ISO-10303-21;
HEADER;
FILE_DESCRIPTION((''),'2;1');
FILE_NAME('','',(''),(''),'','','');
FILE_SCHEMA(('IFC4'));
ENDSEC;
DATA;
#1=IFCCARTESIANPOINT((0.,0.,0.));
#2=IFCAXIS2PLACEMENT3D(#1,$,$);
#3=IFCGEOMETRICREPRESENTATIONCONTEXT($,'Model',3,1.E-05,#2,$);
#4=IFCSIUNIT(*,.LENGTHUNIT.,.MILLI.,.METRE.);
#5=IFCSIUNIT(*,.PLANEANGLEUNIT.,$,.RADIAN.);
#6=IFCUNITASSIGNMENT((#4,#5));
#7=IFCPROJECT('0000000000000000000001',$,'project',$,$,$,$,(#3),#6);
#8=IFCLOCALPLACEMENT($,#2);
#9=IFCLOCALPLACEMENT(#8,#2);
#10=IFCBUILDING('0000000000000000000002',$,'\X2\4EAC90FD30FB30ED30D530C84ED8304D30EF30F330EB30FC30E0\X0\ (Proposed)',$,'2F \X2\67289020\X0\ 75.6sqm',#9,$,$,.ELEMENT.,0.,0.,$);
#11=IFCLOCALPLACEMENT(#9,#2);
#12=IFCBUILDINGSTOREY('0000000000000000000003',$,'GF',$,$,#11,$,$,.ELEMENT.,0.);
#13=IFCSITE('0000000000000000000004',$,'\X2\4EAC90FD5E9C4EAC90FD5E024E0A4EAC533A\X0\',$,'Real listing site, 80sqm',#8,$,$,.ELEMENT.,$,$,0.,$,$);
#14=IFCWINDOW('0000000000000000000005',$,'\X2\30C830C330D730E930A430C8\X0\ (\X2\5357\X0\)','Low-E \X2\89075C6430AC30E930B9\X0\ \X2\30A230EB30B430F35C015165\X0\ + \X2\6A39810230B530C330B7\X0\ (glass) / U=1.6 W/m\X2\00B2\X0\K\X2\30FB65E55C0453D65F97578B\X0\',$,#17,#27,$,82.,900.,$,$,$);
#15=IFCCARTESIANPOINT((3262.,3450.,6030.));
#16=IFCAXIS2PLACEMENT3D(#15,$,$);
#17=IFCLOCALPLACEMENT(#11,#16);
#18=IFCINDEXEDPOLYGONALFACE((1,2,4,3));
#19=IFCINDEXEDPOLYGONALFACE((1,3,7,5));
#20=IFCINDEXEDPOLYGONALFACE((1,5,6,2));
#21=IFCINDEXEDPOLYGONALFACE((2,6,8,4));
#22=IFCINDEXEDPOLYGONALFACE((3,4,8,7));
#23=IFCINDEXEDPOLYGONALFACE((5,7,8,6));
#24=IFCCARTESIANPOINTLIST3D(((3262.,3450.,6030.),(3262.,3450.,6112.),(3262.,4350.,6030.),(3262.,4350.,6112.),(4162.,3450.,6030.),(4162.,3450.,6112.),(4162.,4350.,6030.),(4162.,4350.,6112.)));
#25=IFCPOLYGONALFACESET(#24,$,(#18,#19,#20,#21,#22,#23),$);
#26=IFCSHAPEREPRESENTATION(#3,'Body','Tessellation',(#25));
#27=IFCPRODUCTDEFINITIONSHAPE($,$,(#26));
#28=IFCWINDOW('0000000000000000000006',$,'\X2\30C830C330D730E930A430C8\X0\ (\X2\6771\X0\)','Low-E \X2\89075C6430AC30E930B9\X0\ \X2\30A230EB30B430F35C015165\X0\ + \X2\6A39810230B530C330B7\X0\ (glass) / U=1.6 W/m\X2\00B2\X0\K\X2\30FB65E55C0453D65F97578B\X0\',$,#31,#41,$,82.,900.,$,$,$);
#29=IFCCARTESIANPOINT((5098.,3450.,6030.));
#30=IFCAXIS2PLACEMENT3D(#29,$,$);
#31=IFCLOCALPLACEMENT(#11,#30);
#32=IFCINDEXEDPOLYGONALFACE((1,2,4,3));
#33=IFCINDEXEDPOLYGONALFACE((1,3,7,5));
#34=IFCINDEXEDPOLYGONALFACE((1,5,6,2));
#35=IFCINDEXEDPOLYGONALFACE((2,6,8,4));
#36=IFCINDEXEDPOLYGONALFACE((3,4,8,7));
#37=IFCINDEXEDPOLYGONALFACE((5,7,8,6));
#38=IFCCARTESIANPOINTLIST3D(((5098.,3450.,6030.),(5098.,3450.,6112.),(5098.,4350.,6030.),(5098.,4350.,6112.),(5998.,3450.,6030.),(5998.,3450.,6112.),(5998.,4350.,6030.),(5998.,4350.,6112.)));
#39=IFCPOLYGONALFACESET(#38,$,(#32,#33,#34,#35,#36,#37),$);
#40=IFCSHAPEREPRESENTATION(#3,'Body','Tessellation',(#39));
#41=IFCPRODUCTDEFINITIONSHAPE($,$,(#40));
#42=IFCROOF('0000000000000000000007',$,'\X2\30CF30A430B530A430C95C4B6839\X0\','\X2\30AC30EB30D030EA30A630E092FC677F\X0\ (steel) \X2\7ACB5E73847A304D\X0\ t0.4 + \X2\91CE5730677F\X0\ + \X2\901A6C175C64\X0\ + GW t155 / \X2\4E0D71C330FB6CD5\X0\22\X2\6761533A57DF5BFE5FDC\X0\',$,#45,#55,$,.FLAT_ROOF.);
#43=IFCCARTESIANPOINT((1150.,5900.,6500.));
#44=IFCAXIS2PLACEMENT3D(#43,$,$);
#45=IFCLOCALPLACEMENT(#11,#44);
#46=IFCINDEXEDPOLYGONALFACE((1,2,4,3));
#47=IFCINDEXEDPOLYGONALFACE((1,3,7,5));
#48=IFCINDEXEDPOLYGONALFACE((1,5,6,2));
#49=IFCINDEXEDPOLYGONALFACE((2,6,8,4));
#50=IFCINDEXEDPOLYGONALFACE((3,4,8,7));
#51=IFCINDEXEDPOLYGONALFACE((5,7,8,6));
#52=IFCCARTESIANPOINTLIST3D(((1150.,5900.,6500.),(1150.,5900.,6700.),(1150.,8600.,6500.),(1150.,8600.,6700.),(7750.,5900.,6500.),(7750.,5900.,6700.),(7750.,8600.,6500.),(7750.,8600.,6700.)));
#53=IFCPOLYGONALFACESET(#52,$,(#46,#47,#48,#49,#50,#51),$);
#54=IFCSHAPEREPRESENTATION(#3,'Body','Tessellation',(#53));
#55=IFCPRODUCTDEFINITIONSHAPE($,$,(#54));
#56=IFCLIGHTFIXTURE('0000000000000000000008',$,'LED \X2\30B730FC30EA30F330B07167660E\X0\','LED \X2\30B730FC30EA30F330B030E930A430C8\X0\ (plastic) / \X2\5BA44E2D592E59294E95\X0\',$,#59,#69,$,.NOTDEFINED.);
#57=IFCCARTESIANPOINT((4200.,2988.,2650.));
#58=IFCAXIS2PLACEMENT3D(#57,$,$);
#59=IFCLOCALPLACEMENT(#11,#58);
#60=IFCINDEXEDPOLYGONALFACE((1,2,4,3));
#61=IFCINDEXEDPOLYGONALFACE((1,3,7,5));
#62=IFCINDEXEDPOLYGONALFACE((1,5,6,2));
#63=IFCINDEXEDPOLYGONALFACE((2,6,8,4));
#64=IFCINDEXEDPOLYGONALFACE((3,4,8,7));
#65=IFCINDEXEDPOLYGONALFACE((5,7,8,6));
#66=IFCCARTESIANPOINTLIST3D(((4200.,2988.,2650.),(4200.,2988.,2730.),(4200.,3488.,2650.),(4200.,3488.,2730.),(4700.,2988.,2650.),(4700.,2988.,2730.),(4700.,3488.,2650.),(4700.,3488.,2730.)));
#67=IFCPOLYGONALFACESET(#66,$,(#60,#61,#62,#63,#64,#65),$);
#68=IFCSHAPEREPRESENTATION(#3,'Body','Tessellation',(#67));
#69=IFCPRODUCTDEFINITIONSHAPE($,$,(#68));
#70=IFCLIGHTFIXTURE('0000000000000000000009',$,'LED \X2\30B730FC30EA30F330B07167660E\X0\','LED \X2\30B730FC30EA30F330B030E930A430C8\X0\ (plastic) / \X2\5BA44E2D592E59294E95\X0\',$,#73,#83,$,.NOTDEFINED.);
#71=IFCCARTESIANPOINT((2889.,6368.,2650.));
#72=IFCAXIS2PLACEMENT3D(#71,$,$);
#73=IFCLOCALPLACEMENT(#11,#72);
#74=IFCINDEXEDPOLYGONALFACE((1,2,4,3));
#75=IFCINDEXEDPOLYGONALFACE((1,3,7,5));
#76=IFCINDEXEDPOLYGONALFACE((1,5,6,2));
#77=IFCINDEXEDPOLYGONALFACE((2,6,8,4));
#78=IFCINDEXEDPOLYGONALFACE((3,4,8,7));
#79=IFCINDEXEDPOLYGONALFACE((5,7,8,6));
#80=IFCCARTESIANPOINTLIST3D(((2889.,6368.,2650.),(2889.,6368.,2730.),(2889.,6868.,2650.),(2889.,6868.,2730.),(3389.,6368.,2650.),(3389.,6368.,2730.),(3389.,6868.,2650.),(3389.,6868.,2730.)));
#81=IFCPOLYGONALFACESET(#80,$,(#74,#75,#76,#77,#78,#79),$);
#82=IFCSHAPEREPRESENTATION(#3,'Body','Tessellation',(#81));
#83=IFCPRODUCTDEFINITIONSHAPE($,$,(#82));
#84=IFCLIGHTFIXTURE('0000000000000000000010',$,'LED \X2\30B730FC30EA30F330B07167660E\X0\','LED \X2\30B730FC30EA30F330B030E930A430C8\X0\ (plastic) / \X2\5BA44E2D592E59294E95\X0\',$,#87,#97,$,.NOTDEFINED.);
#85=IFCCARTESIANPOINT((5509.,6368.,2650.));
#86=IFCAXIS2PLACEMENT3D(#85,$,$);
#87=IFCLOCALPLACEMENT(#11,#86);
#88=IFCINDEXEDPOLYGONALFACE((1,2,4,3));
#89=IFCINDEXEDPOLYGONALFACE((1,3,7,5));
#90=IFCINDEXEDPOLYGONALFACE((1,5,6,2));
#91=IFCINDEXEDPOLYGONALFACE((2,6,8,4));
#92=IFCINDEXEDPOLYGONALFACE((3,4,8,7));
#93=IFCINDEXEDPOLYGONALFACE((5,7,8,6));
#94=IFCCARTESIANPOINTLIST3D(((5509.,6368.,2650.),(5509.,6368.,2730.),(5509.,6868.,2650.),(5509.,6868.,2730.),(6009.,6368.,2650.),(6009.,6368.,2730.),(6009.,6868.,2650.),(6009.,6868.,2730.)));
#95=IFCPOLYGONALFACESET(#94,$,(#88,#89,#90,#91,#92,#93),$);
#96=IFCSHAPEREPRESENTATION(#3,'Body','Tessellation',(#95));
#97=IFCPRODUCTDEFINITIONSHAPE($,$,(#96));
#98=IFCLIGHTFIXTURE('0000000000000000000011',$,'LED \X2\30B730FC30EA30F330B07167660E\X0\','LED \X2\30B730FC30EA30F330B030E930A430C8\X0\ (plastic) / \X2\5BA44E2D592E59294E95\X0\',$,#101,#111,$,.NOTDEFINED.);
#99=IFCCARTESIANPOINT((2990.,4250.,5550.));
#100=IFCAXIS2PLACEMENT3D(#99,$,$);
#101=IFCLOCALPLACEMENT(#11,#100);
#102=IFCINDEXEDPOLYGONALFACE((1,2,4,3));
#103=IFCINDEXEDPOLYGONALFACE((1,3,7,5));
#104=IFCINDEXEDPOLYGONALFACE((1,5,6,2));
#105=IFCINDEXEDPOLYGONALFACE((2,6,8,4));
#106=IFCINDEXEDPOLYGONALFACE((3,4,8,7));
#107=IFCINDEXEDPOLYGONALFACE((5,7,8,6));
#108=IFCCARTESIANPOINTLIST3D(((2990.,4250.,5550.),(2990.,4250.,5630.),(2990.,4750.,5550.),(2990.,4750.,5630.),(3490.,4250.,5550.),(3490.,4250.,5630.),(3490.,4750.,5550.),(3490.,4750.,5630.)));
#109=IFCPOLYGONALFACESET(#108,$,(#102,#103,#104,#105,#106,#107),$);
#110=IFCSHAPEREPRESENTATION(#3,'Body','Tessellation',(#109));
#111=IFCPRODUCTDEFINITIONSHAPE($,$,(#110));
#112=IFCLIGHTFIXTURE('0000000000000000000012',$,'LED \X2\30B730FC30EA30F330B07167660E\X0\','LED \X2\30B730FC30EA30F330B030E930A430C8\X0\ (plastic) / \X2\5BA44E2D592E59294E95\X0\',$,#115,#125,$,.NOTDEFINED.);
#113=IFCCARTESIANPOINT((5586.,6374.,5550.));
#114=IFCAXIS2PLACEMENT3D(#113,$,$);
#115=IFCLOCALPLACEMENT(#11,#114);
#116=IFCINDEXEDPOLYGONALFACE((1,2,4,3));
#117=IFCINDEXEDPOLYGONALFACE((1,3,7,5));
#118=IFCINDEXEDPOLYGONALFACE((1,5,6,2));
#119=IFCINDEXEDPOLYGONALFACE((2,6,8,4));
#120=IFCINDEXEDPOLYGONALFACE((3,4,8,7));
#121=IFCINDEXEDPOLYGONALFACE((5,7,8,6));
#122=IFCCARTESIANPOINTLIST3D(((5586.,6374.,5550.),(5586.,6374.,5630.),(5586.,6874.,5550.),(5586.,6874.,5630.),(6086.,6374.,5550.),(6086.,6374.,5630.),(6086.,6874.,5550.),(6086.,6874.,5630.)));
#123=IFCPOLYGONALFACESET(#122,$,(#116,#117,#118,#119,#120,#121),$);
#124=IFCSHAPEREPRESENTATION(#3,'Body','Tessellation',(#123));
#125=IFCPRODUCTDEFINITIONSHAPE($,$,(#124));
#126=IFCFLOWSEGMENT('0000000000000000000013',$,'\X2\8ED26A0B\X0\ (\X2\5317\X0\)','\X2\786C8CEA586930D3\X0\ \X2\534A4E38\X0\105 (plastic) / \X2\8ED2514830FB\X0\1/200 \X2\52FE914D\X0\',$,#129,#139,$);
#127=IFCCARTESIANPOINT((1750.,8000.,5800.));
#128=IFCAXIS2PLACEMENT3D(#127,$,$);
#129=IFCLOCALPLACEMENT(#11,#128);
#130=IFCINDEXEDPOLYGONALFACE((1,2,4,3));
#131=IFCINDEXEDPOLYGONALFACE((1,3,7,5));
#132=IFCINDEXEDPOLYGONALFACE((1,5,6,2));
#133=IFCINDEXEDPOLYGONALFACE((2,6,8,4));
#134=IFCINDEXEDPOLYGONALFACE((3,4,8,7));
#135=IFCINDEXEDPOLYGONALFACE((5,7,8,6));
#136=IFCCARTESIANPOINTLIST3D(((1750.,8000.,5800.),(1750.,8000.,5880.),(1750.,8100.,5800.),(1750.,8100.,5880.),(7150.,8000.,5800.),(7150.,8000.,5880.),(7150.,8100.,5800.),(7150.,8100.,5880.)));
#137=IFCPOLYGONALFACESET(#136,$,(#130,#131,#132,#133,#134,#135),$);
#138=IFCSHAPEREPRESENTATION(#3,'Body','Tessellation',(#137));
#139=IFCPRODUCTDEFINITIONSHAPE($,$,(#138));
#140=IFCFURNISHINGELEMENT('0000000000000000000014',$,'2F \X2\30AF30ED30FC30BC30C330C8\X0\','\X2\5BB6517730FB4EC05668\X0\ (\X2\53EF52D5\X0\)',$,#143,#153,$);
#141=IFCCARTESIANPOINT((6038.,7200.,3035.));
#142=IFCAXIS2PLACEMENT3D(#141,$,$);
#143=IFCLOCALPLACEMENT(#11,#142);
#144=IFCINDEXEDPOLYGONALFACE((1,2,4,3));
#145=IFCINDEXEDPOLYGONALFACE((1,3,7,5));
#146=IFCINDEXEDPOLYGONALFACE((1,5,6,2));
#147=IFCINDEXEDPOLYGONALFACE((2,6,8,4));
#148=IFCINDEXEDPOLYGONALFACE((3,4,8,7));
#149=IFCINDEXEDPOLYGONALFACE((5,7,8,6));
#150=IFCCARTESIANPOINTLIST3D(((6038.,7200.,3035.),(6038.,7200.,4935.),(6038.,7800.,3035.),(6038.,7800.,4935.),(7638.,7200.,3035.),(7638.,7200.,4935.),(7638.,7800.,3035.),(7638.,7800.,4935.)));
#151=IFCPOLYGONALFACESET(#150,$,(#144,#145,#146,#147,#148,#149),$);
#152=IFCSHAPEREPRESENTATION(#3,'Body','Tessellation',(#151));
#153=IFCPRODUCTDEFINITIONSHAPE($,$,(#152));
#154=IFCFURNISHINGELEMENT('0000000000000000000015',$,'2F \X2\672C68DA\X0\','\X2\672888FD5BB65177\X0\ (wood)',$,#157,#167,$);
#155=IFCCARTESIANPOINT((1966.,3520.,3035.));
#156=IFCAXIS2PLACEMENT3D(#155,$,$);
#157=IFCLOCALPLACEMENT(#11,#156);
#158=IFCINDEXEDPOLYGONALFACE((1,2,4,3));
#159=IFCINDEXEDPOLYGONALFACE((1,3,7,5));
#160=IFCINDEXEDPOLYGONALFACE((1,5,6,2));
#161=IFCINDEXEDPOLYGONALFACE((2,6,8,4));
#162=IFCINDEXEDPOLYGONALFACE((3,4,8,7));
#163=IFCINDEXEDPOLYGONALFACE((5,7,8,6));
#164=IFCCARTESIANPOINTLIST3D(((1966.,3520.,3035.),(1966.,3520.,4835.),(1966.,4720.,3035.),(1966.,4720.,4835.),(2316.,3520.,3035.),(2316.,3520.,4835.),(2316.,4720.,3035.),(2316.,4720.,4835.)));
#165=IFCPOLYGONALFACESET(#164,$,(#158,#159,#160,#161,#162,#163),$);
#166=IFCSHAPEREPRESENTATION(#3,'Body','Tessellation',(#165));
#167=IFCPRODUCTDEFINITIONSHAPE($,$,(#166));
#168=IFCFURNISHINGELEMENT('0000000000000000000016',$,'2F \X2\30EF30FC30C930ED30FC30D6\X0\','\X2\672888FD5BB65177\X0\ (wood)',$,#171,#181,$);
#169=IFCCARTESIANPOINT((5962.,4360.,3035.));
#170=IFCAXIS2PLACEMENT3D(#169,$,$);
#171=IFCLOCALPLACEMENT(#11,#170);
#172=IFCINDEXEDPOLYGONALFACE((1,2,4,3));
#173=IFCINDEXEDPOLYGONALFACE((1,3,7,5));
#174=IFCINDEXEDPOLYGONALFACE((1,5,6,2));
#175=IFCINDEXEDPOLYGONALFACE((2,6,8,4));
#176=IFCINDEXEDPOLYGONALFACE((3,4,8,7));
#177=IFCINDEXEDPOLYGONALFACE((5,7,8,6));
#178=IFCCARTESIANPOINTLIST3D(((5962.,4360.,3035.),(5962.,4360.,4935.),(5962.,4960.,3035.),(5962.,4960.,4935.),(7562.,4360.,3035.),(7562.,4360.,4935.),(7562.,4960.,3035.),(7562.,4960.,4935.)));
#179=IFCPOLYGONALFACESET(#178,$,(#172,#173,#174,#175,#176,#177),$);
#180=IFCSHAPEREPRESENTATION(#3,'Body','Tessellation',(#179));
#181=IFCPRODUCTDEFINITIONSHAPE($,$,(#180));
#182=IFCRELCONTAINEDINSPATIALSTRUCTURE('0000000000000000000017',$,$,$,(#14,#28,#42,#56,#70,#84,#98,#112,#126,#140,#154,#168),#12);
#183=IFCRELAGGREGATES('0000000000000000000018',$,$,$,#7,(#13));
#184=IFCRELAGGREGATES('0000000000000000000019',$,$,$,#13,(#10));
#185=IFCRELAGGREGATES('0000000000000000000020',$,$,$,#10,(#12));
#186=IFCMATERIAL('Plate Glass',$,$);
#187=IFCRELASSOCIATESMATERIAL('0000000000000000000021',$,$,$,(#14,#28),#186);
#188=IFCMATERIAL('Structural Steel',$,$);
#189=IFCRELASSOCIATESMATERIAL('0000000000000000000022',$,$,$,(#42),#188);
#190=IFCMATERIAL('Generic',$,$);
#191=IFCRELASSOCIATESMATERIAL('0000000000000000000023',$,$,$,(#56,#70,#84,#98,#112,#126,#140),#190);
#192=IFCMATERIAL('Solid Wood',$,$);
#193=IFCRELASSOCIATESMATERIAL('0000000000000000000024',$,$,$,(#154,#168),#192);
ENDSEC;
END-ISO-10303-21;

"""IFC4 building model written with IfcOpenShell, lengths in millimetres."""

from ifc_helpers import new_model, si_unit, frame, frame_2d, origin, place, context, project, spatial, rectangle, extrude, material, element, save


model = new_model("IFC4")

# Units and contexts
model_context = context("Model", 3, precision=1e-05, world=origin())
ifc_project = project(units=[si_unit("LENGTHUNIT", "METRE", prefix="MILLI"), si_unit("PLANEANGLEUNIT", "RADIAN")], contexts=[model_context])

# Site, building, storey
site_placement = place(None, origin())
site = spatial("IfcSite", under=ifc_project, at=site_placement, Name="京都府京都市上京区", ObjectType="Real listing site, 80sqm", CompositionType="ELEMENT", RefElevation=0.0)
building_placement = place(site_placement, origin())
building = spatial("IfcBuilding", under=site, at=building_placement, Name="京都・ロフト付きワンルーム (Proposed)", ObjectType="2F 木造 75.6sqm", CompositionType="ELEMENT", ElevationOfRefHeight=0.0, ElevationOfTerrain=0.0)
storey_placement = place(building_placement, origin())
storey = spatial("IfcBuildingStorey", under=building, at=storey_placement, Name="GF", CompositionType="ELEMENT", Elevation=0.0)

# Shared definitions
ifc_material_1 = material(Name="Solid Wood")

# Shared definitions
ifc_material_2 = material(Name="Plate Glass")

# Windows
window_1_placement = place(storey_placement, frame((3262.0, 3450.0, 6030.0)))
element("IfcWindow", 1, at=window_1_placement, inside=storey, material=ifc_material_2, Name="トップライト (南)", Description="Low-E 複層ガラス アルゴン封入 + 樹脂サッシ (glass) / U=1.6 W/m²K・日射取得型", OverallHeight=82.0, OverallWidth=900.0, context=model_context, shape_type="SweptSolid", body=[
    extrude(rectangle(XDim=900.0, YDim=900.0, at=frame_2d((450.0, 450.0))), frame((3262.0, 3450.0, 6030.0)), (0.0, 0.0, 1.0), 82.0),
])
window_2_placement = place(storey_placement, frame((5098.0, 3450.0, 6030.0)))
element("IfcWindow", 2, at=window_2_placement, inside=storey, material=ifc_material_2, Name="トップライト (東)", Description="Low-E 複層ガラス アルゴン封入 + 樹脂サッシ (glass) / U=1.6 W/m²K・日射取得型", OverallHeight=82.0, OverallWidth=900.0, context=model_context, shape_type="SweptSolid", body=[
    extrude(rectangle(XDim=900.0, YDim=900.0, at=frame_2d((450.0, 450.0))), frame((5098.0, 3450.0, 6030.0)), (0.0, 0.0, 1.0), 82.0),
])

# Roof
ifc_material_3 = material(Name="Structural Steel")
roof_placement = place(storey_placement, frame((1150.0, 5900.0, 6500.0)))
element("IfcRoof", 3, at=roof_placement, inside=storey, material=ifc_material_3, Name="ハイサイド屋根", Description="ガルバリウム鋼板 (steel) 立平葺き t0.4 + 野地板 + 通気層 + GW t155 / 不燃・法22条区域対応", PredefinedType="FLAT_ROOF", context=model_context, shape_type="SweptSolid", body=[
    extrude(rectangle(XDim=6600.0, YDim=2700.0, at=frame_2d((3300.0, 1350.0))), frame((1150.0, 5900.0, 6500.0)), (0.0, 0.0, 1.0), 200.0),
])

# Light fixtures
ifc_material_4 = material(Name="Generic")
light_fixture_1_placement = place(storey_placement, frame((4200.0, 2988.0, 2650.0)))
element("IfcLightFixture", 4, at=light_fixture_1_placement, inside=storey, material=ifc_material_4, Name="LED シーリング照明", Description="LED シーリングライト (plastic) / 室中央天井", PredefinedType="NOTDEFINED", context=model_context, shape_type="SweptSolid", body=[
    extrude(rectangle(XDim=500.0, YDim=500.0, at=frame_2d((250.0, 250.0))), frame((4200.0, 2988.0, 2650.0)), (0.0, 0.0, 1.0), 80.0),
])
light_fixture_2_placement = place(storey_placement, frame((2889.0, 6368.0, 2650.0)))
element("IfcLightFixture", 5, at=light_fixture_2_placement, inside=storey, material=ifc_material_4, Name="LED シーリング照明", Description="LED シーリングライト (plastic) / 室中央天井", PredefinedType="NOTDEFINED", context=model_context, shape_type="SweptSolid", body=[
    extrude(rectangle(XDim=500.0, YDim=500.0, at=frame_2d((250.0, 250.0))), frame((2889.0, 6368.0, 2650.0)), (0.0, 0.0, 1.0), 80.0),
])
light_fixture_3_placement = place(storey_placement, frame((5509.0, 6368.0, 2650.0)))
element("IfcLightFixture", 6, at=light_fixture_3_placement, inside=storey, material=ifc_material_4, Name="LED シーリング照明", Description="LED シーリングライト (plastic) / 室中央天井", PredefinedType="NOTDEFINED", context=model_context, shape_type="SweptSolid", body=[
    extrude(rectangle(XDim=500.0, YDim=500.0, at=frame_2d((250.0, 250.0))), frame((5509.0, 6368.0, 2650.0)), (0.0, 0.0, 1.0), 80.0),
])
light_fixture_4_placement = place(storey_placement, frame((2990.0, 4250.0, 5550.0)))
element("IfcLightFixture", 7, at=light_fixture_4_placement, inside=storey, material=ifc_material_4, Name="LED シーリング照明", Description="LED シーリングライト (plastic) / 室中央天井", PredefinedType="NOTDEFINED", context=model_context, shape_type="SweptSolid", body=[
    extrude(rectangle(XDim=500.0, YDim=500.0, at=frame_2d((250.0, 250.0))), frame((2990.0, 4250.0, 5550.0)), (0.0, 0.0, 1.0), 80.0),
])
light_fixture_5_placement = place(storey_placement, frame((5586.0, 6374.0, 5550.0)))
element("IfcLightFixture", 8, at=light_fixture_5_placement, inside=storey, material=ifc_material_4, Name="LED シーリング照明", Description="LED シーリングライト (plastic) / 室中央天井", PredefinedType="NOTDEFINED", context=model_context, shape_type="SweptSolid", body=[
    extrude(rectangle(XDim=500.0, YDim=500.0, at=frame_2d((250.0, 250.0))), frame((5586.0, 6374.0, 5550.0)), (0.0, 0.0, 1.0), 80.0),
])

# Flow segment
flow_segment_placement = place(storey_placement, frame((1750.0, 8000.0, 5800.0)))
element("IfcFlowSegment", 9, at=flow_segment_placement, inside=storey, material=ifc_material_4, Name="軒樋 (北)", Description="硬質塩ビ 半丸105 (plastic) / 軒先・1/200 勾配", context=model_context, shape_type="SweptSolid", body=[
    extrude(rectangle(XDim=5400.0, YDim=100.0, at=frame_2d((2700.0, 50.0))), frame((1750.0, 8000.0, 5800.0)), (0.0, 0.0, 1.0), 80.0),
])

# Furnishing elements
furnishing_1_placement = place(storey_placement, frame((6038.0, 7200.0, 3035.0)))
element("IfcFurnishingElement", 10, at=furnishing_1_placement, inside=storey, material=ifc_material_4, Name="2F クローゼット", Description="家具・什器 (可動)", context=model_context, shape_type="SweptSolid", body=[
    extrude(rectangle(XDim=1600.0, YDim=600.0, at=frame_2d((800.0, 300.0))), frame((6038.0, 7200.0, 3035.0)), (0.0, 0.0, 1.0), 1900.0),
])
furnishing_2_placement = place(storey_placement, frame((1966.0, 3520.0, 3035.0)))
element("IfcFurnishingElement", 11, at=furnishing_2_placement, inside=storey, material=ifc_material_1, Name="2F 本棚", Description="木製家具 (wood)", context=model_context, shape_type="SweptSolid", body=[
    extrude(rectangle(XDim=350.0, YDim=1200.0, at=frame_2d((175.0, 600.0))), frame((1966.0, 3520.0, 3035.0)), (0.0, 0.0, 1.0), 1800.0),
])
furnishing_3_placement = place(storey_placement, frame((5962.0, 4360.0, 3035.0)))
element("IfcFurnishingElement", 12, at=furnishing_3_placement, inside=storey, material=ifc_material_1, Name="2F ワードローブ", Description="木製家具 (wood)", context=model_context, shape_type="SweptSolid", body=[
    extrude(rectangle(XDim=1600.0, YDim=600.0, at=frame_2d((800.0, 300.0))), frame((5962.0, 4360.0, 3035.0)), (0.0, 0.0, 1.0), 1900.0),
])

save(model, "model.ifc")
